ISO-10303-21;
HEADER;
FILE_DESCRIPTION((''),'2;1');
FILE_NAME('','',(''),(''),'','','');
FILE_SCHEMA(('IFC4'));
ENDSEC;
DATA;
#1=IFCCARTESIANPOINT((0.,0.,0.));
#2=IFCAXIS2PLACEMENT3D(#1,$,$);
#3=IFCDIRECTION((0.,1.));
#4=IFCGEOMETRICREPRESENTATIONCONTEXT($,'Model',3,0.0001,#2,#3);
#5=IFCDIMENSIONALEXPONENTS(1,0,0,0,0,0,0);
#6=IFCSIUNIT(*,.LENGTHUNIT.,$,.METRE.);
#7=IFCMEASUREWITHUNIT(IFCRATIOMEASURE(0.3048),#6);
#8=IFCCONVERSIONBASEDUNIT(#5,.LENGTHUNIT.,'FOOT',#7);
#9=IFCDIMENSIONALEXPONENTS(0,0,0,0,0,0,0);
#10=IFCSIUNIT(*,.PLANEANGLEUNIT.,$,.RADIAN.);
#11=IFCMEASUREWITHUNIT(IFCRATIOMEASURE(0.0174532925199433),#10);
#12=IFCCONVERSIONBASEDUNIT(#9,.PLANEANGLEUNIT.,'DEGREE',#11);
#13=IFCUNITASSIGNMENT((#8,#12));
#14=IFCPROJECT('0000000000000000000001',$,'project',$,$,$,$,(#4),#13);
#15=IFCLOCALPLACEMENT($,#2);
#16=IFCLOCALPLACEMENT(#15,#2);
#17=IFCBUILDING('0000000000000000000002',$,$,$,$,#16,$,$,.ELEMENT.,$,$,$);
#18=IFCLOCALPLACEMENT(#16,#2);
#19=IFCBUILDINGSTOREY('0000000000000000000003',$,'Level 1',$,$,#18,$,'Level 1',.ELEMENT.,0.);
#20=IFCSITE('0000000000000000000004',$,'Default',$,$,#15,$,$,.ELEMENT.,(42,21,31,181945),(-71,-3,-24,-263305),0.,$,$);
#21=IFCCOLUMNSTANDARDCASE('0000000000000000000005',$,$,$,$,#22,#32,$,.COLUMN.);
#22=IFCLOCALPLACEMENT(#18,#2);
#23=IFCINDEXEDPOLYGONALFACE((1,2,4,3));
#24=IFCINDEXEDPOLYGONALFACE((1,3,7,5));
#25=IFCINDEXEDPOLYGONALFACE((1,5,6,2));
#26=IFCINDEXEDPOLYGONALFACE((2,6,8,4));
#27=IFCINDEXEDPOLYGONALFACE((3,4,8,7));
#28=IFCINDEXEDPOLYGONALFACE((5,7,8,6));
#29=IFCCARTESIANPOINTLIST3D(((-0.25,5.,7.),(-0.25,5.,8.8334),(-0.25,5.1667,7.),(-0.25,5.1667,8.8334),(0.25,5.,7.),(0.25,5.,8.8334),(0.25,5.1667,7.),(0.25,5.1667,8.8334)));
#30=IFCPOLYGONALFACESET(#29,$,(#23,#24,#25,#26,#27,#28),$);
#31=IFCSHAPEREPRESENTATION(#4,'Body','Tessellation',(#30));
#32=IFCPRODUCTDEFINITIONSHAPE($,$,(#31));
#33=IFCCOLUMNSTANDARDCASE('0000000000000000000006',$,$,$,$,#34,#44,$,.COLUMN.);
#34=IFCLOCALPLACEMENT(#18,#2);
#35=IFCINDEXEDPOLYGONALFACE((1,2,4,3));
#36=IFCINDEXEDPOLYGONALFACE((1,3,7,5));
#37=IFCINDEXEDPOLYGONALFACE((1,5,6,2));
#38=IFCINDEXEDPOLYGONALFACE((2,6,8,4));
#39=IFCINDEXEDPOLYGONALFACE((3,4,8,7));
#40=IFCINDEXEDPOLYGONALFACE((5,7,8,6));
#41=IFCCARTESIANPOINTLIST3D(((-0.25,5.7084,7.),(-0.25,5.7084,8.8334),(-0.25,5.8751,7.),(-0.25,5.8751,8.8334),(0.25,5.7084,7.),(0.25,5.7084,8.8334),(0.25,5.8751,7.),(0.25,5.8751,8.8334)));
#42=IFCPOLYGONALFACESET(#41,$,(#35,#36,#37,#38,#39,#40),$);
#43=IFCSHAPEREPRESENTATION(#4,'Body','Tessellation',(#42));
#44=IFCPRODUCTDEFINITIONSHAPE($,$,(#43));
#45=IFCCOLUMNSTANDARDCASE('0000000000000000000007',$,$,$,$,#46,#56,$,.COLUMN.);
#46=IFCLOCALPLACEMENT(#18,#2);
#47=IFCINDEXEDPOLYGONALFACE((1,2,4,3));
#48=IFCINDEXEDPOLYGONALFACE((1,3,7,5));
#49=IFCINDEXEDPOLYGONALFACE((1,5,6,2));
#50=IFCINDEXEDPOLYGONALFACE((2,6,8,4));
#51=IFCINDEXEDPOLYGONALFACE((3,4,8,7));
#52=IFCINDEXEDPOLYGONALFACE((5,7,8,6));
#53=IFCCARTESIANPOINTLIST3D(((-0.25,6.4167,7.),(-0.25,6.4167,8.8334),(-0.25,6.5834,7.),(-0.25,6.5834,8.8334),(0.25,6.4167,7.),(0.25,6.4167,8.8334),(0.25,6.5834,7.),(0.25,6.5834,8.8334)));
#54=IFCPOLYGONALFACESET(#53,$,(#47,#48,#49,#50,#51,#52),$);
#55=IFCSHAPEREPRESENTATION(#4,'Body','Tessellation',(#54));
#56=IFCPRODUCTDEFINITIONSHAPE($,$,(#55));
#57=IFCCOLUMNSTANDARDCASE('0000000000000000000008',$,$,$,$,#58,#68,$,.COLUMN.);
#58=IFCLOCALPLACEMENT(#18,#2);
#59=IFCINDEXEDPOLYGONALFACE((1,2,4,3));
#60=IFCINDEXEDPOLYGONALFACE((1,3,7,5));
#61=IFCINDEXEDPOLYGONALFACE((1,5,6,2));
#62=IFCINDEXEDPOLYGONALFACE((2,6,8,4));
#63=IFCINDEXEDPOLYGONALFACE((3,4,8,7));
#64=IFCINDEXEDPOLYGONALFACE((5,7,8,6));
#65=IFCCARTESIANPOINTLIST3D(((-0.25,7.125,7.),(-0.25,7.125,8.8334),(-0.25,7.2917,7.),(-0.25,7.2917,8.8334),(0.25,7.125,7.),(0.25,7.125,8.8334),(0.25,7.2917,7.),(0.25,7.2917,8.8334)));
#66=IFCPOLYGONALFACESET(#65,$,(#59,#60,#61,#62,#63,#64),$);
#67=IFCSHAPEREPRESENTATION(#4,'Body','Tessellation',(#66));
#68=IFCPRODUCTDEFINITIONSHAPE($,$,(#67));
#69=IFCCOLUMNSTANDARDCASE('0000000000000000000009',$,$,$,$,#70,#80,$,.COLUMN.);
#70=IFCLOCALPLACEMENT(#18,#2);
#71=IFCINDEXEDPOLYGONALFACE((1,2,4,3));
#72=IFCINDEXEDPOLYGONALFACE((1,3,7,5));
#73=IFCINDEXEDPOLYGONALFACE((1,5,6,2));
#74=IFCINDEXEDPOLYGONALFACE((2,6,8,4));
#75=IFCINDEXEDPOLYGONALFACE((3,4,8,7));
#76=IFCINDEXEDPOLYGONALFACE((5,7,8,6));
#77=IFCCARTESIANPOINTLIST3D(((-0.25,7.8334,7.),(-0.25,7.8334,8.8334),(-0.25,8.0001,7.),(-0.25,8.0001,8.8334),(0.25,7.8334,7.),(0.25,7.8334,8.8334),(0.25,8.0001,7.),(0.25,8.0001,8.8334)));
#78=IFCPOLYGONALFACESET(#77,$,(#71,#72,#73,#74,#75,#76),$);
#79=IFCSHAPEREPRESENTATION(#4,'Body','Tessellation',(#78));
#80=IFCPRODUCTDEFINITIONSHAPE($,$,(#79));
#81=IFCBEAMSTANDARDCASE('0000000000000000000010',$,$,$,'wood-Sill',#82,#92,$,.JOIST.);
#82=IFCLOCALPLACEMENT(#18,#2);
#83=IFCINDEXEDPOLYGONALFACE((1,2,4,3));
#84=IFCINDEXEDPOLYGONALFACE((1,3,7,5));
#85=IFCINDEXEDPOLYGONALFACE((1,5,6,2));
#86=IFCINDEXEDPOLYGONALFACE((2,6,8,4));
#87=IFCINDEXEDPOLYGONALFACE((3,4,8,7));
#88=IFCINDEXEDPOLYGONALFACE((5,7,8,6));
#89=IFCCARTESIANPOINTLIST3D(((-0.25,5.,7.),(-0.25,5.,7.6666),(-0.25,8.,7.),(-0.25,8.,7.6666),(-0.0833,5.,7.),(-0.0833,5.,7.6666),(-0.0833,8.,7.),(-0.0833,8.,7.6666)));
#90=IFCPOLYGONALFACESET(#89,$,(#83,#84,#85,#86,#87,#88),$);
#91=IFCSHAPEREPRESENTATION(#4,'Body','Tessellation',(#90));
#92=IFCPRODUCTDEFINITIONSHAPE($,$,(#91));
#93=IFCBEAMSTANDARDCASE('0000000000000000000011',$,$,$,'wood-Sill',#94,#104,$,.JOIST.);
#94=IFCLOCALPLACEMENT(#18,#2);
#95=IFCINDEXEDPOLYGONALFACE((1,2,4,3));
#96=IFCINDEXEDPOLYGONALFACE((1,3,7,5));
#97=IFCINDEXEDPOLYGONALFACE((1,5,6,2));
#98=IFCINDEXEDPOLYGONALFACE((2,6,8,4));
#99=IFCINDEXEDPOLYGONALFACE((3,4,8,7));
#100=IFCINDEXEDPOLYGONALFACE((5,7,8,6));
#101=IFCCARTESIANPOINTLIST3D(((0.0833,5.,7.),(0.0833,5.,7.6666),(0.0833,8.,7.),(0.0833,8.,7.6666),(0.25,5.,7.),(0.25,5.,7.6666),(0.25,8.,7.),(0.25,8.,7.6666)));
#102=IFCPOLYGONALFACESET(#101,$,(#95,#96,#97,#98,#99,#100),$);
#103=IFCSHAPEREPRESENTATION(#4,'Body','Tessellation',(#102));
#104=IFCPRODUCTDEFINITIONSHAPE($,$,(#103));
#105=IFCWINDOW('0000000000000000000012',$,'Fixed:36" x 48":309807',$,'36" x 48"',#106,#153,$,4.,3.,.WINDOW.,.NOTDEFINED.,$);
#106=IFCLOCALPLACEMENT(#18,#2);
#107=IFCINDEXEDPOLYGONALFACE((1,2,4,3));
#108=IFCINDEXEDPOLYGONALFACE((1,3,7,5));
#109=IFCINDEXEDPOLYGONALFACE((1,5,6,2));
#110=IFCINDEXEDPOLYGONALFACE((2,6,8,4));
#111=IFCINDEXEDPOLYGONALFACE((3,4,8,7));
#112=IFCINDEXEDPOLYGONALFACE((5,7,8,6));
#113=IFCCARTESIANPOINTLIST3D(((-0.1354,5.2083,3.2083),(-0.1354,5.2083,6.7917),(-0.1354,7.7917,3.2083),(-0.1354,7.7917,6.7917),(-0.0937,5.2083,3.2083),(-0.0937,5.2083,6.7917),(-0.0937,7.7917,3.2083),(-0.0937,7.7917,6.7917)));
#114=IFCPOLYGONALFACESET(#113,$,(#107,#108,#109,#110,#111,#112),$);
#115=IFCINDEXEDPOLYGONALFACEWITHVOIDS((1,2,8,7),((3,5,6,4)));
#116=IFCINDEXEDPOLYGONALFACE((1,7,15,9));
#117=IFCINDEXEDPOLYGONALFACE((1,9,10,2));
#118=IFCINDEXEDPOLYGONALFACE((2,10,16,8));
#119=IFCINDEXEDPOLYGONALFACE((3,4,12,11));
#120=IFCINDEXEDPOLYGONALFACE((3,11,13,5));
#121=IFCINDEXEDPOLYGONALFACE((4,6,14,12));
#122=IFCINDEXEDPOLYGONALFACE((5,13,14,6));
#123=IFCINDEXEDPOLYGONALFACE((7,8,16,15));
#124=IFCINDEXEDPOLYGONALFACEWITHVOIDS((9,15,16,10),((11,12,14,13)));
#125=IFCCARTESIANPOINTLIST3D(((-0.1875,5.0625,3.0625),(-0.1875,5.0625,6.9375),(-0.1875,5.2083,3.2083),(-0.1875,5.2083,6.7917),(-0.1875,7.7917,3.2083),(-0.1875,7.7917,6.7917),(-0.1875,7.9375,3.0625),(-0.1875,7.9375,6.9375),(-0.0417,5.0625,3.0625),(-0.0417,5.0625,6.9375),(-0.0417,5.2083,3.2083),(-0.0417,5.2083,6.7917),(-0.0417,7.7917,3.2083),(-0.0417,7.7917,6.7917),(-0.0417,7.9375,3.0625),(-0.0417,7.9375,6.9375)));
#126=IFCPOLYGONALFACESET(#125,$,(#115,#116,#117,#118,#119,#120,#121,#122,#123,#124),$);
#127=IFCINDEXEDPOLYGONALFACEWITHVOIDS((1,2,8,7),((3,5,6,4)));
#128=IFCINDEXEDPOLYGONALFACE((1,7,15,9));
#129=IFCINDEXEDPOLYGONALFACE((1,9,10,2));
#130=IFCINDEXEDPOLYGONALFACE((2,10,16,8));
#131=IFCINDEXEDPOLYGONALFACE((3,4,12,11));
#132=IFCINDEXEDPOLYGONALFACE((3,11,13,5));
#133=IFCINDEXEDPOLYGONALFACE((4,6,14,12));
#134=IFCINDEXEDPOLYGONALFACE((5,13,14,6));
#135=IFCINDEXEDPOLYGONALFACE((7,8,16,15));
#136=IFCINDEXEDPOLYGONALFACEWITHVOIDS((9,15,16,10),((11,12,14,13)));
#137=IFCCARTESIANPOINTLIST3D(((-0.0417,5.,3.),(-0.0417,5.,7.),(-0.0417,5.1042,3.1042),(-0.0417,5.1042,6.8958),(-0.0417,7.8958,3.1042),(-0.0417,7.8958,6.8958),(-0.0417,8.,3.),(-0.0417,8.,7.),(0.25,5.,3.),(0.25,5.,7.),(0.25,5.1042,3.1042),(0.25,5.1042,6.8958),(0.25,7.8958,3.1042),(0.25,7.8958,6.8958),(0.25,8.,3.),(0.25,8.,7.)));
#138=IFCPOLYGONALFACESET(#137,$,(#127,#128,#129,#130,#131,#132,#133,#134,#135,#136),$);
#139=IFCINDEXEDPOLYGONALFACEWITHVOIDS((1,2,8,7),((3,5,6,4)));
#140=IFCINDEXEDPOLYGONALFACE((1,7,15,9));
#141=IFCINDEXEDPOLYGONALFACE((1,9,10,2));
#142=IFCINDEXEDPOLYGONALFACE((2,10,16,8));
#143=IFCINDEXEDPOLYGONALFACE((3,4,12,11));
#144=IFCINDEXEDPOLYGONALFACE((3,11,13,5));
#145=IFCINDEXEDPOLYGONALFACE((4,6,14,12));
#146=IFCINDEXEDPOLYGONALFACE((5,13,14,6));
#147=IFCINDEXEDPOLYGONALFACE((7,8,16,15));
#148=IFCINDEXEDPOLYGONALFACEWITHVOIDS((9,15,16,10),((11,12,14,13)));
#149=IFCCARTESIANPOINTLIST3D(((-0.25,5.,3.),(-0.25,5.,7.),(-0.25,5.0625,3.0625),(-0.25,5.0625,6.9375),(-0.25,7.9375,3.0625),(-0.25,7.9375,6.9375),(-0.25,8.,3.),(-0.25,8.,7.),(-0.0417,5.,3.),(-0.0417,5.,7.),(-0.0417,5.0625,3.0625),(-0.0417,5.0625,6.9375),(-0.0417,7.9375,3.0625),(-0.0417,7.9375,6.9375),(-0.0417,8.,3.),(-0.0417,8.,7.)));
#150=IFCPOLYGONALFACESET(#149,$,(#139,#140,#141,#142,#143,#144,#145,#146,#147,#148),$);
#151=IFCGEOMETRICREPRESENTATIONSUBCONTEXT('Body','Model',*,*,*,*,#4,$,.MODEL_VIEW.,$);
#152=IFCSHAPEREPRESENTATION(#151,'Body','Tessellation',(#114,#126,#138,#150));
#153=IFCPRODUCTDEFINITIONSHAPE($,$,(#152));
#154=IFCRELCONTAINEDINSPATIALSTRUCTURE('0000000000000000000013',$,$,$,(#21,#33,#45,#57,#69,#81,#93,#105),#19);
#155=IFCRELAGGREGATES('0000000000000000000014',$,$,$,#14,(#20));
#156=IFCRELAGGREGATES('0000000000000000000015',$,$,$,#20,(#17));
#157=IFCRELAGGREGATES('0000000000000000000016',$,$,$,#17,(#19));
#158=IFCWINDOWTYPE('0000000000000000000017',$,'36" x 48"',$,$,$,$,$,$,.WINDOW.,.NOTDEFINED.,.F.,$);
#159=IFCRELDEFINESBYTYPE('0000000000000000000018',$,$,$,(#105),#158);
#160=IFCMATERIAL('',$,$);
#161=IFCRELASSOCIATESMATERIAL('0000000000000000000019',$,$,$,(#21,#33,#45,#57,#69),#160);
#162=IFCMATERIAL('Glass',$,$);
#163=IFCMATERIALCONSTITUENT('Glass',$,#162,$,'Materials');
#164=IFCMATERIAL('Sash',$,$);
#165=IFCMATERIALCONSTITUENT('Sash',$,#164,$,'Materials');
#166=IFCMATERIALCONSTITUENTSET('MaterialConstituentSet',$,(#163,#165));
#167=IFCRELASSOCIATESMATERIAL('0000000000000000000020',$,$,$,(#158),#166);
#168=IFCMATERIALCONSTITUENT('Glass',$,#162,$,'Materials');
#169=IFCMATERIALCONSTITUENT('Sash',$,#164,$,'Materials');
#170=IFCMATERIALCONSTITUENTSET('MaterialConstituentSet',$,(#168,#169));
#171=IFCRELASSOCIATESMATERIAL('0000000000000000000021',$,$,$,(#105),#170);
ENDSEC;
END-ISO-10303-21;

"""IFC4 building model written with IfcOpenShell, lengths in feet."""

from ifc_helpers import new_model, entity, si_unit, converted_unit, direction, frame, frame_2d, origin, origin_with_axes, place, context, subcontext, project, spatial, polyline, rectangle, outline, extrude, source, transform, mapped, material, constituent, constituent_set, type_object, type_shapes, element, save


model = new_model("IFC4")

# Units and contexts
model_context = context("Model", 3, precision=0.0001, world=origin(), true_north=direction((0.0, 1.0)))
body_context = subcontext(model_context, "Body", "Model", "MODEL_VIEW")
ifc_project = project(units=[converted_unit("LENGTHUNIT", "FOOT", entity("IfcRatioMeasure", 0.3048), si_unit("LENGTHUNIT", "METRE"), dimensions=[1, 0, 0, 0, 0, 0, 0]), converted_unit("PLANEANGLEUNIT", "DEGREE", entity("IfcRatioMeasure", 0.0174532925199433), si_unit("PLANEANGLEUNIT", "RADIAN"), dimensions=[0, 0, 0, 0, 0, 0, 0])], contexts=[model_context])

# Site, building, storey
site_placement = place(None, origin())
site = spatial("IfcSite", under=ifc_project, at=site_placement, Name="Default", CompositionType="ELEMENT", RefLatitude=(42, 21, 31, 181945), RefLongitude=(-71, -3, -24, -263305), RefElevation=0.0)
building_placement = place(site_placement, origin())
building = spatial("IfcBuilding", under=site, at=building_placement, CompositionType="ELEMENT")
storey_placement = place(building_placement, origin())
storey = spatial("IfcBuildingStorey", under=building, at=storey_placement, Name="Level 1", LongName="Level 1", CompositionType="ELEMENT", Elevation=0.0)

# Columns
placement_1 = place(storey_placement, frame((0.0, -0.25, 0.0), z_axis=(0.0, 0.0, 1.0), x_axis=(0.0, 1.0, 0.0)))
ifc_material_1 = material(Name="")
for number, where, z_axis, x_axis in (
    (1, (5.3333, 0.0, 7.0), (0.0, 0.0, 1.0), (1.0, 0.0, 0.0)),
    (2, (6.0417, 0.0, 7.0), (0.0, 0.0, 1.0), (1.0, 0.0, 0.0)),
    (3, (6.75, 0.0, 7.0), (0.0, 0.0, 1.0), (1.0, 0.0, 0.0)),
    (4, (7.4583, 0.0, 7.0), (0.0, 0.0, 1.0), (1.0, 0.0, 0.0)),
    (5, (8.1667, 0.0, 7.0), (0.0, 0.0, 1.0), (1.0, 0.0, 0.0)),
):
    element("IfcColumnStandardCase", number, at=place(placement_1, frame(where, z_axis=z_axis, x_axis=x_axis)), inside=storey, material=ifc_material_1, PredefinedType="COLUMN", context=model_context, shape_type="SweptSolid", body=[
        extrude(rectangle(XDim=0.1667, YDim=0.5), origin(), (0.0, 0.0, 1.0), 1.8334),
    ])

# Beams
for number, where, z_axis, x_axis in (
    (6, (5.25, 0.1667, 7.3333), (1.0, 0.0, 0.0), (0.0, 0.0, 1.0)),
    (7, (5.25, -0.1667, 7.3333), (1.0, 0.0, 0.0), (0.0, 0.0, 1.0)),
):
    element("IfcBeamStandardCase", number, at=place(placement_1, frame(where, z_axis=z_axis, x_axis=x_axis)), inside=storey, ObjectType="wood-Sill", PredefinedType="JOIST", context=model_context, shape_type="SweptSolid", body=[
        extrude(rectangle(XDim=0.6667, YDim=0.1667), origin_with_axes(), (0.0, 0.0, 1.0), 3.0),
    ])

# Window
ifc_material_2 = material(Name="Glass")
ifc_constituent_1 = constituent(ifc_material_2, Name="Glass", Category="Materials")
ifc_material_3 = material(Name="Sash")
ifc_constituent_2 = constituent(ifc_material_3, Name="Sash", Category="Materials")
ifc_constituent_set_1 = constituent_set(constituents=[ifc_constituent_1, ifc_constituent_2], Name="MaterialConstituentSet")
ifc_constituent_3 = constituent(ifc_material_2, Name="Glass", Category="Materials")
ifc_constituent_4 = constituent(ifc_material_3, Name="Sash", Category="Materials")
ifc_constituent_set_2 = constituent_set(constituents=[ifc_constituent_3, ifc_constituent_4], Name="MaterialConstituentSet")
window_type = type_object("IfcWindowType", Name="36\" x 48\"", ParameterTakesPrecedence=False, PartitioningType="NOTDEFINED", PredefinedType="WINDOW", material=ifc_constituent_set_2)
shared_shape = source(origin(), body_context, "Body", "SweptSolid", [
    extrude(rectangle(XDim=0.0417, YDim=2.5833, at=frame_2d((0.0, 0.0), x_axis=(1.0, 0.0))), frame((1.5, 0.3646, 0.2083), z_axis=(0.0, 0.0, 1.0), x_axis=(0.0, 1.0, 0.0)), (0.0, 0.0, 1.0), 3.5833),
    extrude(outline(polyline([(-1.4375, -1.9375), (1.4375, -1.9375), (1.4375, 1.9375), (-1.4375, 1.9375), (-1.4375, -1.9375)]), holes=[polyline([(-1.2917, -1.7917), (-1.2917, 1.7917), (1.2917, 1.7917), (1.2917, -1.7917), (-1.2917, -1.7917)])]), frame((1.5, 0.2917, 2.0), z_axis=(0.0, 1.0, 0.0), x_axis=(1.0, 0.0, 0.0)), (0.0, 0.0, 1.0), 0.1458),
    extrude(outline(polyline([(-1.5, -2.0), (1.5, -2.0), (1.5, 2.0), (-1.5, 2.0), (-1.5, -2.0)]), holes=[polyline([(-1.3958, -1.8958), (-1.3958, 1.8958), (1.3958, 1.8958), (1.3958, -1.8958), (-1.3958, -1.8958)])]), frame((1.5, 0.0, 2.0), z_axis=(0.0, 1.0, 0.0), x_axis=(1.0, 0.0, 0.0)), (0.0, 0.0, 1.0), 0.2917),
    extrude(outline(polyline([(-2.0, -1.5), (2.0, -1.5), (2.0, 1.5), (-2.0, 1.5), (-2.0, -1.5)]), holes=[polyline([(-1.9375, -1.4375), (-1.9375, 1.4375), (1.9375, 1.4375), (1.9375, -1.4375), (-1.9375, -1.4375)])]), frame((1.5, 0.2917, 2.0), z_axis=(0.0, 1.0, 0.0), x_axis=(0.0, 0.0, -1.0)), (0.0, 0.0, 1.0), 0.2083),
])
type_shapes(window_type, [shared_shape])
placement_2 = place(placement_1, frame((5.25, -0.25, 3.0)))
window_placement = place(placement_2, origin())
element("IfcWindow", 8, at=window_placement, inside=storey, type_object=window_type, material=ifc_constituent_set_1, Name="Fixed:36\" x 48\":309807", ObjectType="36\" x 48\"", OverallHeight=4.0, OverallWidth=3.0, PartitioningType="NOTDEFINED", PredefinedType="WINDOW", context=body_context, shape_type="MappedRepresentation", body=[
    mapped(shared_shape, transform((0.0, 0.0, 0.0), scale=1.0)),
])

save(model, "model.ifc")
